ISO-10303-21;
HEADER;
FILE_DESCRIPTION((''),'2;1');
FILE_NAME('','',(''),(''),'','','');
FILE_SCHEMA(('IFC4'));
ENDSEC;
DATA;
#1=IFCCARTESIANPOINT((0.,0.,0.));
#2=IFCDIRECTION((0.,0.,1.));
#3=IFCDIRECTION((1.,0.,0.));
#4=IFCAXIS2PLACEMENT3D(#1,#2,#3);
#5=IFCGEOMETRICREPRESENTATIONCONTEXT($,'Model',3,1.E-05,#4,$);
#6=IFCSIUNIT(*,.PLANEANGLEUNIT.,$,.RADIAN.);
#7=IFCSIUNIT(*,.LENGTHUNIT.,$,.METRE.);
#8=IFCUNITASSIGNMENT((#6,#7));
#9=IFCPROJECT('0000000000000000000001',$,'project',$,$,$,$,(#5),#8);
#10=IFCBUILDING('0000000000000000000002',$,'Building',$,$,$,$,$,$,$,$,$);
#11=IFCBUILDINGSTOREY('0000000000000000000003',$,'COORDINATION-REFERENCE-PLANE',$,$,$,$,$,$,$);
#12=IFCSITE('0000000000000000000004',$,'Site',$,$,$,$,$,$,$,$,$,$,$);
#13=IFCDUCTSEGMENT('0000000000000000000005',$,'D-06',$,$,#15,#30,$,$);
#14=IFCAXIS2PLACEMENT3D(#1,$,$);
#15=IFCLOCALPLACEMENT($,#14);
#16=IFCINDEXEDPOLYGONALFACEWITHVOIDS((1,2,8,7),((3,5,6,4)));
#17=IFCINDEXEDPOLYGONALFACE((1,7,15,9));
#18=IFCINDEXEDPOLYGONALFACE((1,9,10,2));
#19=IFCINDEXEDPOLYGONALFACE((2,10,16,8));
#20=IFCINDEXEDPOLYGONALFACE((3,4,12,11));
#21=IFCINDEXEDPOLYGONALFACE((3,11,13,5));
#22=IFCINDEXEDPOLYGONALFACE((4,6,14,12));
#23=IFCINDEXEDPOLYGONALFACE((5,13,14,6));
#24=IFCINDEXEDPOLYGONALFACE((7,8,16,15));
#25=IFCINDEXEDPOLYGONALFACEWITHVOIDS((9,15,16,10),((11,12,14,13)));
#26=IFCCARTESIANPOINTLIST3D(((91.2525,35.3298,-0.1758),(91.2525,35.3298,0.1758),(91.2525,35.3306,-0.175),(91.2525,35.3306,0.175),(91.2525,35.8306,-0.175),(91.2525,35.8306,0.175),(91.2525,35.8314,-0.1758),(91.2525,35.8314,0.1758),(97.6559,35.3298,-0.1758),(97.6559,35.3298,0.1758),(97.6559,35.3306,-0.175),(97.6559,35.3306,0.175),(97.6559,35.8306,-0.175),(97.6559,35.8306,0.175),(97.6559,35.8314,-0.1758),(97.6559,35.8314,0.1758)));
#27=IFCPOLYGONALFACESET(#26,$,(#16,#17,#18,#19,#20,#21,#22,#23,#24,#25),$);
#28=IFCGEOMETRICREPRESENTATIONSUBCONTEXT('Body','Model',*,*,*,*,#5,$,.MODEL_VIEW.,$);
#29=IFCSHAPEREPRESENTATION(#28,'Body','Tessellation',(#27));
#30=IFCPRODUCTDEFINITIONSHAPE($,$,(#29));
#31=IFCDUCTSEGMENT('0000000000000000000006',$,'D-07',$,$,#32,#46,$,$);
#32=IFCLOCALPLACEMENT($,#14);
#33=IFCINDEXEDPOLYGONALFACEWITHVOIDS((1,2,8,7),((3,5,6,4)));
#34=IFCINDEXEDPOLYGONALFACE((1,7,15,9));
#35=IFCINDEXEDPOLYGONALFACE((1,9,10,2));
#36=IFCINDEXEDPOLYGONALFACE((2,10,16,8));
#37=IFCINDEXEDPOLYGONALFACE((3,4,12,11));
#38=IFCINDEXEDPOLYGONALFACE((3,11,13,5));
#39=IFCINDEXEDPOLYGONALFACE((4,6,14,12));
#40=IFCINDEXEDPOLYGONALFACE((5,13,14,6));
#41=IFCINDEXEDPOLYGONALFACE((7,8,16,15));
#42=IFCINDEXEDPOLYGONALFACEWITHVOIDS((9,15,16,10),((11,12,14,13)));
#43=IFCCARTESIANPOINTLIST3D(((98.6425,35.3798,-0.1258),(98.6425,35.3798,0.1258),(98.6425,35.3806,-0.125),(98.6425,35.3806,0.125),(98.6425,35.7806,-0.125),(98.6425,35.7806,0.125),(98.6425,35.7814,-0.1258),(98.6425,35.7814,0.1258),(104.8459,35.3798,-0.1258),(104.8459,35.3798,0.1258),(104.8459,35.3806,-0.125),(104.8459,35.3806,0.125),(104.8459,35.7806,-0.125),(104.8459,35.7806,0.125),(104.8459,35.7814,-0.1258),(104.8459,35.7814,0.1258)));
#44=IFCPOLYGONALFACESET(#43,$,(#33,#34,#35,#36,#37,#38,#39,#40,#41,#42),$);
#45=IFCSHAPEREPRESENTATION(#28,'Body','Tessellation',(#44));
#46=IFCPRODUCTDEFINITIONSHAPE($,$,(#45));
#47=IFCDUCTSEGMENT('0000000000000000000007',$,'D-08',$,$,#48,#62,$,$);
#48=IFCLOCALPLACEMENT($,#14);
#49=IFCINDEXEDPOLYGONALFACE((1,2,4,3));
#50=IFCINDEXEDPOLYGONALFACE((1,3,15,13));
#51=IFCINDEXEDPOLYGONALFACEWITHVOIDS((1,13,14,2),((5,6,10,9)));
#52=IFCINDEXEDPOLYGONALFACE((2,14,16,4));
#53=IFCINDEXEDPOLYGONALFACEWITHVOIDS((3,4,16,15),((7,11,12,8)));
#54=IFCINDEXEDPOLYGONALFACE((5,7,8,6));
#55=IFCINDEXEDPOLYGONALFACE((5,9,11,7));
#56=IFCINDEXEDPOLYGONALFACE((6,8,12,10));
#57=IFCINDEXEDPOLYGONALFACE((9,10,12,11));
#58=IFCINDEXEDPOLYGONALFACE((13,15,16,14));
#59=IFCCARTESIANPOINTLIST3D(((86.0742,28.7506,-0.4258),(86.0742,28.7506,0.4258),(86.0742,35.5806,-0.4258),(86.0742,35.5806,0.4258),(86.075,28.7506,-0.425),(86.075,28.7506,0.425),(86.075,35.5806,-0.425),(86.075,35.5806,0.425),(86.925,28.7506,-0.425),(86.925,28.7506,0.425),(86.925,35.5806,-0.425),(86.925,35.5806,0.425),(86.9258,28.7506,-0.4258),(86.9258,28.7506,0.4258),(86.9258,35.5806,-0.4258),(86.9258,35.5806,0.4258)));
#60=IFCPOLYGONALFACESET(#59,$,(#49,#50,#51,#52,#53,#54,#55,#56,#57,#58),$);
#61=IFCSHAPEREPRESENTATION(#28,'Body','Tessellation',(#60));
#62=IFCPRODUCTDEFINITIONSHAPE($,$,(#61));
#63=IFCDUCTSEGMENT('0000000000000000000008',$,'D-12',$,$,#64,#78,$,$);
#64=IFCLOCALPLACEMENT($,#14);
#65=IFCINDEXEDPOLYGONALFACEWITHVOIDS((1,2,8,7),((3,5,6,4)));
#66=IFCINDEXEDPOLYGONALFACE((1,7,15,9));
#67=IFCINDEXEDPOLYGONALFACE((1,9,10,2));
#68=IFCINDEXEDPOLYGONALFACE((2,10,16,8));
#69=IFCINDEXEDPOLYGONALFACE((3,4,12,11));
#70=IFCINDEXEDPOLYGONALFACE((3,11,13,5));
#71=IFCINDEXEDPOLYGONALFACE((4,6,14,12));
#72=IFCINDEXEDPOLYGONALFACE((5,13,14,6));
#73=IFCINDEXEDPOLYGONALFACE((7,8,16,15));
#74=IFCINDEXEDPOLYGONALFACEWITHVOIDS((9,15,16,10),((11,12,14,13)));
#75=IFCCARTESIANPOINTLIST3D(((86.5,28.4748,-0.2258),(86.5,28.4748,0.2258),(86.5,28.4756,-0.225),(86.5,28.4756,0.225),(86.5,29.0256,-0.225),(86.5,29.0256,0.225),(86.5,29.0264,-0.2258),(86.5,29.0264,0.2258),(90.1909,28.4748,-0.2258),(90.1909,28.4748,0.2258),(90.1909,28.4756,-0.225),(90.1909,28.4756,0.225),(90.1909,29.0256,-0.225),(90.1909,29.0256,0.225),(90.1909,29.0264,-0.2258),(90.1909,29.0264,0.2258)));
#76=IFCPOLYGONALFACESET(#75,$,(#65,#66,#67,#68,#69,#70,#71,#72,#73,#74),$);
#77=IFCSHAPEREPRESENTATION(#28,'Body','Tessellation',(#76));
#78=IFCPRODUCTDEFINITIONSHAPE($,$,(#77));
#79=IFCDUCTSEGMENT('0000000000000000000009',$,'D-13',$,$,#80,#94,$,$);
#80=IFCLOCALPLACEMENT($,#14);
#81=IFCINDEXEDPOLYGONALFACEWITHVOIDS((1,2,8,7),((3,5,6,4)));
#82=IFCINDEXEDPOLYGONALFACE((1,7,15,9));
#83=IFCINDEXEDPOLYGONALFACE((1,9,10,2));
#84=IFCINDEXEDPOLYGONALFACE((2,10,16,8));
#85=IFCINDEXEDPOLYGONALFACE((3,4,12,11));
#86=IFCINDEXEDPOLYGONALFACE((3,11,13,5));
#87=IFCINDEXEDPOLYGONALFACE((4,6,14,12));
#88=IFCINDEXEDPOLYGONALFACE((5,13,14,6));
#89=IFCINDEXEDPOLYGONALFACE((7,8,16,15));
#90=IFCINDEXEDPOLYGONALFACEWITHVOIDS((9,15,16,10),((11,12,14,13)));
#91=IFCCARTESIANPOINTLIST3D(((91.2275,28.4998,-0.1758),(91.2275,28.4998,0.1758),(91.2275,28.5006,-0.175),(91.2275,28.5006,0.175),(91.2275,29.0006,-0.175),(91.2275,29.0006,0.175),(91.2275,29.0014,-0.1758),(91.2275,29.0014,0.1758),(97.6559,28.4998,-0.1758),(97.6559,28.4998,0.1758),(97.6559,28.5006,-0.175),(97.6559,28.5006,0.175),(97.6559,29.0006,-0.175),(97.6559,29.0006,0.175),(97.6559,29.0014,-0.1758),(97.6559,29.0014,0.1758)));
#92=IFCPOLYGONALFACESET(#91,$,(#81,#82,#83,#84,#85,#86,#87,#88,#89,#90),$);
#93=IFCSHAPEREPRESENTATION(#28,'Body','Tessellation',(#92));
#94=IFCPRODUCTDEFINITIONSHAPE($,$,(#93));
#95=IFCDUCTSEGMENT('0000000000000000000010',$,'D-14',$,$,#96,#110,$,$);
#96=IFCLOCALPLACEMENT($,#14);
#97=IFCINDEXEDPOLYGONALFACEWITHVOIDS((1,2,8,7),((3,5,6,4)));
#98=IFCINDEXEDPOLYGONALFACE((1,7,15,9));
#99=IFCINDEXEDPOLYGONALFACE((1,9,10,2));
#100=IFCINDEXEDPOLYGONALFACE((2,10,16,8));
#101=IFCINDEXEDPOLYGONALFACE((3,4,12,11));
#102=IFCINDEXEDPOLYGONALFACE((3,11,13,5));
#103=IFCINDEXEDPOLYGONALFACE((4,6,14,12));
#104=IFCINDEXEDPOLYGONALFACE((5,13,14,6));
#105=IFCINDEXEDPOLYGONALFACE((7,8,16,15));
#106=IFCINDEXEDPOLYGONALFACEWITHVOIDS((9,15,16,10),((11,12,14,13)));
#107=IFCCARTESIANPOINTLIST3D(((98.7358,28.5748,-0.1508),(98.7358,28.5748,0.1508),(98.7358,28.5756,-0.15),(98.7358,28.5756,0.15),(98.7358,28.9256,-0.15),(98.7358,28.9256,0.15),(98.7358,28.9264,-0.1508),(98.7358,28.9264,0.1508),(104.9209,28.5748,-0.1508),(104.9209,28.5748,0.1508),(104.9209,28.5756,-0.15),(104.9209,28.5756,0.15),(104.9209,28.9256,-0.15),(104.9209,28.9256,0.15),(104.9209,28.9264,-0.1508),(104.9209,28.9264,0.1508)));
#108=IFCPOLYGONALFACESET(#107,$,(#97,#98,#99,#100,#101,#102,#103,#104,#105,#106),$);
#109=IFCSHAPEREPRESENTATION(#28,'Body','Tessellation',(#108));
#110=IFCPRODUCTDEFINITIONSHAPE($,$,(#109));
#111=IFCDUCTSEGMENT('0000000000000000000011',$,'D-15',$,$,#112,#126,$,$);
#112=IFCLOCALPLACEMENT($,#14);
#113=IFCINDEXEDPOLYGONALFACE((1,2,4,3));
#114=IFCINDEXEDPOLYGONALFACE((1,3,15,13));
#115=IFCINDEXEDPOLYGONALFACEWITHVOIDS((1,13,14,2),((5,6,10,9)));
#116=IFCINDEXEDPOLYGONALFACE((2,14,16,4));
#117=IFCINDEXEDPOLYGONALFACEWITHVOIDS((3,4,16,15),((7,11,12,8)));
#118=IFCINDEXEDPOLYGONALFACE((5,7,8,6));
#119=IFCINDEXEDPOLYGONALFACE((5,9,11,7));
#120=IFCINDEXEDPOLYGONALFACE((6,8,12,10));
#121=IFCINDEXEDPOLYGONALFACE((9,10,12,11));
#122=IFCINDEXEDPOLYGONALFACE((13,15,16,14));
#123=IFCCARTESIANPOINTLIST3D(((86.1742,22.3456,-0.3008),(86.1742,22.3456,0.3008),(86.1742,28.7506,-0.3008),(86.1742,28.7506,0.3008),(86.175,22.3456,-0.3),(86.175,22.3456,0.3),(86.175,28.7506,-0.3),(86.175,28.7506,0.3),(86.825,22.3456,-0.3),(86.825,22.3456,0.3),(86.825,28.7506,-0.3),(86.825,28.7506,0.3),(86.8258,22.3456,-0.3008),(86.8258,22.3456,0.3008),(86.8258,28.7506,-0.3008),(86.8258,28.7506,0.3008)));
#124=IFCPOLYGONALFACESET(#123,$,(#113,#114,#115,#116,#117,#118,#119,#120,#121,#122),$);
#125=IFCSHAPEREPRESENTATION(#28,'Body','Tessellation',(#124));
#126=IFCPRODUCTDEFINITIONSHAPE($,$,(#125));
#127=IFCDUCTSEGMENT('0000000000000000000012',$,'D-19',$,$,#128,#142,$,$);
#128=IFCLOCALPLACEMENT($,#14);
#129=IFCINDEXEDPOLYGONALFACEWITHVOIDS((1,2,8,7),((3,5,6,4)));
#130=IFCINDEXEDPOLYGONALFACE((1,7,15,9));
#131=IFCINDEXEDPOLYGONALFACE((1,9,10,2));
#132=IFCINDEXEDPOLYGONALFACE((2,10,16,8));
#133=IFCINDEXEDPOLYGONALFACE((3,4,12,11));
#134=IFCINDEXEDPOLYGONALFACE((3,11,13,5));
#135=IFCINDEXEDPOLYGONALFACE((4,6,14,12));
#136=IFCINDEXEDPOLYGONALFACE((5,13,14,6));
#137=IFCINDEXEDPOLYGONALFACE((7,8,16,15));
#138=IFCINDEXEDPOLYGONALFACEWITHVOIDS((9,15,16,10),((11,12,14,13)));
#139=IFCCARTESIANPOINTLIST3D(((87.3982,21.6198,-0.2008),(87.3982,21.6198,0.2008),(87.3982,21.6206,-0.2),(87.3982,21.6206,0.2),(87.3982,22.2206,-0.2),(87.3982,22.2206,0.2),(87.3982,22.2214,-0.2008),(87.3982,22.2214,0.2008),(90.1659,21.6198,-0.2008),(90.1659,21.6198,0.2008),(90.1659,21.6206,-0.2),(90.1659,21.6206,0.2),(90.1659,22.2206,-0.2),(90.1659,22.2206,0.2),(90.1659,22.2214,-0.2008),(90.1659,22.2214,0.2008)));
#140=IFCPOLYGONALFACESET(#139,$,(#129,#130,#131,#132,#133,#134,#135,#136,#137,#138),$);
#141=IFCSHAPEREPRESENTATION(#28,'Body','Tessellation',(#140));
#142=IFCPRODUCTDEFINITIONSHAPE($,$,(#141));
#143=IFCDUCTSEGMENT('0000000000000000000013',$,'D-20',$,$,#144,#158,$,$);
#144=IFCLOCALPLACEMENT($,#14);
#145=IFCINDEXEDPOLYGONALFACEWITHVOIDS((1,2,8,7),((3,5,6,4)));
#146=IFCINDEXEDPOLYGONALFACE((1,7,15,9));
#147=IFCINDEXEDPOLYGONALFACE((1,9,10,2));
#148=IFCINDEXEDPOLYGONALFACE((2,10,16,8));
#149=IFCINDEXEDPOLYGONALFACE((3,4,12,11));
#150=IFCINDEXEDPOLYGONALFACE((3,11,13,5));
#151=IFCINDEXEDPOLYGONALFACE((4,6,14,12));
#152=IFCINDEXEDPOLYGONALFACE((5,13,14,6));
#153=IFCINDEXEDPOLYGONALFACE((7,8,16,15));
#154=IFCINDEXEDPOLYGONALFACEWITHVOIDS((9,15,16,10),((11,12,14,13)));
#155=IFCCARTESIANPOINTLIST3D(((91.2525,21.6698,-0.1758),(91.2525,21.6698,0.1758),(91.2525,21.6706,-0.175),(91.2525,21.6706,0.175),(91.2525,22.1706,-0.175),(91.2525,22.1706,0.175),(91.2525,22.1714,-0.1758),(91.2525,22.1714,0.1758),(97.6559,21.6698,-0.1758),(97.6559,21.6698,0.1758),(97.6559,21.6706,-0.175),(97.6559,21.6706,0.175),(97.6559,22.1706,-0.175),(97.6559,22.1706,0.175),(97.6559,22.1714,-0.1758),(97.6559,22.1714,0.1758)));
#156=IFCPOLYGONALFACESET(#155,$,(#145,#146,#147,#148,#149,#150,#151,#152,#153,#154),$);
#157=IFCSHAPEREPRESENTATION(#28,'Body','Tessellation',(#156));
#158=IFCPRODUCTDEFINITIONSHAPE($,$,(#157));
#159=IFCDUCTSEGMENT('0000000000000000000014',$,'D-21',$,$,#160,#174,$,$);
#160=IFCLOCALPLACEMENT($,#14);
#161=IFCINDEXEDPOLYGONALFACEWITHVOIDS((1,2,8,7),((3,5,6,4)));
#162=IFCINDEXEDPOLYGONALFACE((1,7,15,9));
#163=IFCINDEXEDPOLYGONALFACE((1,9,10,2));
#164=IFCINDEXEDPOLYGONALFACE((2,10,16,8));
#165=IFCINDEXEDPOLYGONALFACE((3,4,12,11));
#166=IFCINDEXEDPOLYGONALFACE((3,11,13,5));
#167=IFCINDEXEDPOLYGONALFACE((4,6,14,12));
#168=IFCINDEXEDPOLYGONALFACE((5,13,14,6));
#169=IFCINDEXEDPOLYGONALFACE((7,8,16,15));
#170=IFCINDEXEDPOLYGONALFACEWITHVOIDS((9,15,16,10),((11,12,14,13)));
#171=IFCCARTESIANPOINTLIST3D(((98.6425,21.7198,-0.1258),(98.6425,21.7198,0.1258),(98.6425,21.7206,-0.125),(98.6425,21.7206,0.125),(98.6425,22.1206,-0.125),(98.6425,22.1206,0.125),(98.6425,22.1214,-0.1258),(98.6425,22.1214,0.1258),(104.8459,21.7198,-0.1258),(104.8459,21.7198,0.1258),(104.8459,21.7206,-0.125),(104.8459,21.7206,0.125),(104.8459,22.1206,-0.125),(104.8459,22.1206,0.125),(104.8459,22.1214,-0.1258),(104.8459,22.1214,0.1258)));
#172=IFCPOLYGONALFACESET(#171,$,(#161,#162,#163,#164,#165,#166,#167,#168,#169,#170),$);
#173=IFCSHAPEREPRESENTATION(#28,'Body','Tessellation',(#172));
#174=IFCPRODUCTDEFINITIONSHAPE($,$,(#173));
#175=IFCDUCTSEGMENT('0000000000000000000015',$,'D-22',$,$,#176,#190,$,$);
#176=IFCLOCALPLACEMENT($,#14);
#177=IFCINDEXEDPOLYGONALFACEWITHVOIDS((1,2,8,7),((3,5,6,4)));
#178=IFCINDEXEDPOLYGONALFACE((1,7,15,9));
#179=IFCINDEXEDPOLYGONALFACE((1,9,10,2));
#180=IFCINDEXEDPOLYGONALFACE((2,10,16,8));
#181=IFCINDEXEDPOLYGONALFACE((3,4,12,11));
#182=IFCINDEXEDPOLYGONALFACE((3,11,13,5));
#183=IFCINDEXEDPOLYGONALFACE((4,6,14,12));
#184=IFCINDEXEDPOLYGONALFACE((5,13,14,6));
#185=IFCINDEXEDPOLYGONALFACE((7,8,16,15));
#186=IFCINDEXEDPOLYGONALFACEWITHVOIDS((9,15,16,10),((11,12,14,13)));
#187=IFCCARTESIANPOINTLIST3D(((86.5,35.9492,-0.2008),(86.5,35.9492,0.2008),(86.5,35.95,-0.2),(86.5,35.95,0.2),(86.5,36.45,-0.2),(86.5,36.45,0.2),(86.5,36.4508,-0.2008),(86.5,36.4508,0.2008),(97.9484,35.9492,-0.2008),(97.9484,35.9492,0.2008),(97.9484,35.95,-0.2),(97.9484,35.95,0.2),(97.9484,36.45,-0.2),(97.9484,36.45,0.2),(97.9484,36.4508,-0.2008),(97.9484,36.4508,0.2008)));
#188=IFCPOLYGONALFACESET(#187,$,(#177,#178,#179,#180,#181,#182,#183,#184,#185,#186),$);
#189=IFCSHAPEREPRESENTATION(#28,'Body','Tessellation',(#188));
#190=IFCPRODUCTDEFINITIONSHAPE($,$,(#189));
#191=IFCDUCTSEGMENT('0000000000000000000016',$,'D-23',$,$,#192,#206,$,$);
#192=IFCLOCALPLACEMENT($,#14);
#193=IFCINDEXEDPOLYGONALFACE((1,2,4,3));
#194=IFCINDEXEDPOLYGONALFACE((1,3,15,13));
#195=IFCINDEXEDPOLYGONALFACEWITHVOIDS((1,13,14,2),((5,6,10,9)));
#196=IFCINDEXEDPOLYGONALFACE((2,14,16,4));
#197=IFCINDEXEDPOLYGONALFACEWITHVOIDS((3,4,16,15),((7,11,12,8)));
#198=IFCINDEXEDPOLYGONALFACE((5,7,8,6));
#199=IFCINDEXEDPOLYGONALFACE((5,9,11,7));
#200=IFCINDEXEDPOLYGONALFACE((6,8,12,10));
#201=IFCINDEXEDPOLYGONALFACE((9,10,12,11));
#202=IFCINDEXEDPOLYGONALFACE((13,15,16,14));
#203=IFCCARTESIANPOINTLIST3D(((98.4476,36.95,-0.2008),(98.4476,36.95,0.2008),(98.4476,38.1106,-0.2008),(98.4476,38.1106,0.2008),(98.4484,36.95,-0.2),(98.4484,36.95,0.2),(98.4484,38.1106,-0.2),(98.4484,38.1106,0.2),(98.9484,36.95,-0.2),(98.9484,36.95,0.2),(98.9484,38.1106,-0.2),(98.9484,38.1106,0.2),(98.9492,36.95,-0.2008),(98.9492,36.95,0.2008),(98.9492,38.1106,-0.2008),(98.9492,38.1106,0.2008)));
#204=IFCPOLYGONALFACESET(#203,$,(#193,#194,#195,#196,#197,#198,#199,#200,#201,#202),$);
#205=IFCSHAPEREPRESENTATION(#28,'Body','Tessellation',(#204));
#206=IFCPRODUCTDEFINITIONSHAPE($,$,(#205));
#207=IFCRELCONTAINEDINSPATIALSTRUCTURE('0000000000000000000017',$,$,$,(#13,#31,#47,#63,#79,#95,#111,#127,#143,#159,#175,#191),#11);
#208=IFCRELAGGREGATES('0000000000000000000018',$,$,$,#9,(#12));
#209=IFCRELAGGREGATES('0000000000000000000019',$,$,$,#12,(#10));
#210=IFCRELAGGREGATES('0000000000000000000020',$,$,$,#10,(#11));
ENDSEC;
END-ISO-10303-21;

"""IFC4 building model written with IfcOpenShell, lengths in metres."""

from ifc_helpers import new_model, si_unit, frame, origin, origin_with_axes, place, context, subcontext, project, spatial, hollow_rectangle, extrude, element, save


model = new_model("IFC4")

# Units and contexts
model_context = context("Model", 3, precision=1e-05, world=origin_with_axes())
body_context = subcontext(model_context, "Body", "Model", "MODEL_VIEW")
ifc_project = project(units=[si_unit("PLANEANGLEUNIT", "RADIAN"), si_unit("LENGTHUNIT", "METRE")], contexts=[model_context])

# Site, building, storey
site = spatial("IfcSite", under=ifc_project, Name="Site")
building = spatial("IfcBuilding", under=site, Name="Building")
storey = spatial("IfcBuildingStorey", under=building, Name="COORDINATION-REFERENCE-PLANE")

# Duct segments
duct_segment_1_placement = place(None, frame((91.2525, 35.5806, 0.0), z_axis=(1.0, 0.0, 0.0), x_axis=(0.0, 1.0, 0.0)))
element("IfcDuctSegment", 1, at=duct_segment_1_placement, inside=storey, Name="D-06", context=body_context, shape_type="SweptSolid", body=[
    extrude(hollow_rectangle(XDim=0.5016, YDim=0.3516, WallThickness=0.0008), origin(), (0.0, 0.0, 1.0), 6.4034),
])
duct_segment_2_placement = place(None, frame((98.6425, 35.5806, 0.0), z_axis=(1.0, 0.0, 0.0), x_axis=(0.0, 1.0, 0.0)))
element("IfcDuctSegment", 2, at=duct_segment_2_placement, inside=storey, Name="D-07", context=body_context, shape_type="SweptSolid", body=[
    extrude(hollow_rectangle(XDim=0.4016, YDim=0.2516, WallThickness=0.0008), origin(), (0.0, 0.0, 1.0), 6.2034),
])
duct_segment_3_placement = place(None, frame((86.5, 28.7506, 0.0), z_axis=(0.0, 1.0, 0.0), x_axis=(1.0, 0.0, 0.0)))
element("IfcDuctSegment", 3, at=duct_segment_3_placement, inside=storey, Name="D-08", context=body_context, shape_type="SweptSolid", body=[
    extrude(hollow_rectangle(XDim=0.8516, YDim=0.8516, WallThickness=0.0008), origin(), (0.0, 0.0, 1.0), 6.83),
])
duct_segment_4_placement = place(None, frame((86.5, 28.7506, 0.0), z_axis=(1.0, 0.0, 0.0), x_axis=(0.0, 1.0, 0.0)))
element("IfcDuctSegment", 4, at=duct_segment_4_placement, inside=storey, Name="D-12", context=body_context, shape_type="SweptSolid", body=[
    extrude(hollow_rectangle(XDim=0.5516, YDim=0.4516, WallThickness=0.0008), origin(), (0.0, 0.0, 1.0), 3.6909),
])
duct_segment_5_placement = place(None, frame((91.2275, 28.7506, 0.0), z_axis=(1.0, 0.0, 0.0), x_axis=(0.0, 1.0, 0.0)))
element("IfcDuctSegment", 5, at=duct_segment_5_placement, inside=storey, Name="D-13", context=body_context, shape_type="SweptSolid", body=[
    extrude(hollow_rectangle(XDim=0.5016, YDim=0.3516, WallThickness=0.0008), origin(), (0.0, 0.0, 1.0), 6.4284),
])
duct_segment_6_placement = place(None, frame((98.7358, 28.7506, 0.0), z_axis=(1.0, 0.0, 0.0), x_axis=(0.0, 1.0, 0.0)))
element("IfcDuctSegment", 6, at=duct_segment_6_placement, inside=storey, Name="D-14", context=body_context, shape_type="SweptSolid", body=[
    extrude(hollow_rectangle(XDim=0.3516, YDim=0.3016, WallThickness=0.0008), origin(), (0.0, 0.0, 1.0), 6.1851),
])
duct_segment_7_placement = place(None, frame((86.5, 22.3456, 0.0), z_axis=(0.0, 1.0, 0.0), x_axis=(1.0, 0.0, 0.0)))
element("IfcDuctSegment", 7, at=duct_segment_7_placement, inside=storey, Name="D-15", context=body_context, shape_type="SweptSolid", body=[
    extrude(hollow_rectangle(XDim=0.6516, YDim=0.6016, WallThickness=0.0008), origin(), (0.0, 0.0, 1.0), 6.405),
])
duct_segment_8_placement = place(None, frame((87.3982, 21.9206, 0.0), z_axis=(1.0, 0.0, 0.0), x_axis=(0.0, 1.0, 0.0)))
element("IfcDuctSegment", 8, at=duct_segment_8_placement, inside=storey, Name="D-19", context=body_context, shape_type="SweptSolid", body=[
    extrude(hollow_rectangle(XDim=0.6016, YDim=0.4016, WallThickness=0.0008), origin(), (0.0, 0.0, 1.0), 2.7677),
])
duct_segment_9_placement = place(None, frame((91.2525, 21.9206, 0.0), z_axis=(1.0, 0.0, 0.0), x_axis=(0.0, 1.0, 0.0)))
element("IfcDuctSegment", 9, at=duct_segment_9_placement, inside=storey, Name="D-20", context=body_context, shape_type="SweptSolid", body=[
    extrude(hollow_rectangle(XDim=0.5016, YDim=0.3516, WallThickness=0.0008), origin(), (0.0, 0.0, 1.0), 6.4034),
])
duct_segment_10_placement = place(None, frame((98.6425, 21.9206, 0.0), z_axis=(1.0, 0.0, 0.0), x_axis=(0.0, 1.0, 0.0)))
element("IfcDuctSegment", 10, at=duct_segment_10_placement, inside=storey, Name="D-21", context=body_context, shape_type="SweptSolid", body=[
    extrude(hollow_rectangle(XDim=0.4016, YDim=0.2516, WallThickness=0.0008), origin(), (0.0, 0.0, 1.0), 6.2034),
])
duct_segment_11_placement = place(None, frame((86.5, 36.2, 0.0), z_axis=(1.0, 0.0, 0.0), x_axis=(0.0, 1.0, 0.0)))
element("IfcDuctSegment", 11, at=duct_segment_11_placement, inside=storey, Name="D-22", context=body_context, shape_type="SweptSolid", body=[
    extrude(hollow_rectangle(XDim=0.5016, YDim=0.4016, WallThickness=0.0008), origin(), (0.0, 0.0, 1.0), 11.4484),
])
duct_segment_12_placement = place(None, frame((98.6984, 36.95, 0.0), z_axis=(0.0, 1.0, 0.0), x_axis=(1.0, 0.0, 0.0)))
element("IfcDuctSegment", 12, at=duct_segment_12_placement, inside=storey, Name="D-23", context=body_context, shape_type="SweptSolid", body=[
    extrude(hollow_rectangle(XDim=0.5016, YDim=0.4016, WallThickness=0.0008), origin(), (0.0, 0.0, 1.0), 1.1606),
])

save(model, "model.ifc")
